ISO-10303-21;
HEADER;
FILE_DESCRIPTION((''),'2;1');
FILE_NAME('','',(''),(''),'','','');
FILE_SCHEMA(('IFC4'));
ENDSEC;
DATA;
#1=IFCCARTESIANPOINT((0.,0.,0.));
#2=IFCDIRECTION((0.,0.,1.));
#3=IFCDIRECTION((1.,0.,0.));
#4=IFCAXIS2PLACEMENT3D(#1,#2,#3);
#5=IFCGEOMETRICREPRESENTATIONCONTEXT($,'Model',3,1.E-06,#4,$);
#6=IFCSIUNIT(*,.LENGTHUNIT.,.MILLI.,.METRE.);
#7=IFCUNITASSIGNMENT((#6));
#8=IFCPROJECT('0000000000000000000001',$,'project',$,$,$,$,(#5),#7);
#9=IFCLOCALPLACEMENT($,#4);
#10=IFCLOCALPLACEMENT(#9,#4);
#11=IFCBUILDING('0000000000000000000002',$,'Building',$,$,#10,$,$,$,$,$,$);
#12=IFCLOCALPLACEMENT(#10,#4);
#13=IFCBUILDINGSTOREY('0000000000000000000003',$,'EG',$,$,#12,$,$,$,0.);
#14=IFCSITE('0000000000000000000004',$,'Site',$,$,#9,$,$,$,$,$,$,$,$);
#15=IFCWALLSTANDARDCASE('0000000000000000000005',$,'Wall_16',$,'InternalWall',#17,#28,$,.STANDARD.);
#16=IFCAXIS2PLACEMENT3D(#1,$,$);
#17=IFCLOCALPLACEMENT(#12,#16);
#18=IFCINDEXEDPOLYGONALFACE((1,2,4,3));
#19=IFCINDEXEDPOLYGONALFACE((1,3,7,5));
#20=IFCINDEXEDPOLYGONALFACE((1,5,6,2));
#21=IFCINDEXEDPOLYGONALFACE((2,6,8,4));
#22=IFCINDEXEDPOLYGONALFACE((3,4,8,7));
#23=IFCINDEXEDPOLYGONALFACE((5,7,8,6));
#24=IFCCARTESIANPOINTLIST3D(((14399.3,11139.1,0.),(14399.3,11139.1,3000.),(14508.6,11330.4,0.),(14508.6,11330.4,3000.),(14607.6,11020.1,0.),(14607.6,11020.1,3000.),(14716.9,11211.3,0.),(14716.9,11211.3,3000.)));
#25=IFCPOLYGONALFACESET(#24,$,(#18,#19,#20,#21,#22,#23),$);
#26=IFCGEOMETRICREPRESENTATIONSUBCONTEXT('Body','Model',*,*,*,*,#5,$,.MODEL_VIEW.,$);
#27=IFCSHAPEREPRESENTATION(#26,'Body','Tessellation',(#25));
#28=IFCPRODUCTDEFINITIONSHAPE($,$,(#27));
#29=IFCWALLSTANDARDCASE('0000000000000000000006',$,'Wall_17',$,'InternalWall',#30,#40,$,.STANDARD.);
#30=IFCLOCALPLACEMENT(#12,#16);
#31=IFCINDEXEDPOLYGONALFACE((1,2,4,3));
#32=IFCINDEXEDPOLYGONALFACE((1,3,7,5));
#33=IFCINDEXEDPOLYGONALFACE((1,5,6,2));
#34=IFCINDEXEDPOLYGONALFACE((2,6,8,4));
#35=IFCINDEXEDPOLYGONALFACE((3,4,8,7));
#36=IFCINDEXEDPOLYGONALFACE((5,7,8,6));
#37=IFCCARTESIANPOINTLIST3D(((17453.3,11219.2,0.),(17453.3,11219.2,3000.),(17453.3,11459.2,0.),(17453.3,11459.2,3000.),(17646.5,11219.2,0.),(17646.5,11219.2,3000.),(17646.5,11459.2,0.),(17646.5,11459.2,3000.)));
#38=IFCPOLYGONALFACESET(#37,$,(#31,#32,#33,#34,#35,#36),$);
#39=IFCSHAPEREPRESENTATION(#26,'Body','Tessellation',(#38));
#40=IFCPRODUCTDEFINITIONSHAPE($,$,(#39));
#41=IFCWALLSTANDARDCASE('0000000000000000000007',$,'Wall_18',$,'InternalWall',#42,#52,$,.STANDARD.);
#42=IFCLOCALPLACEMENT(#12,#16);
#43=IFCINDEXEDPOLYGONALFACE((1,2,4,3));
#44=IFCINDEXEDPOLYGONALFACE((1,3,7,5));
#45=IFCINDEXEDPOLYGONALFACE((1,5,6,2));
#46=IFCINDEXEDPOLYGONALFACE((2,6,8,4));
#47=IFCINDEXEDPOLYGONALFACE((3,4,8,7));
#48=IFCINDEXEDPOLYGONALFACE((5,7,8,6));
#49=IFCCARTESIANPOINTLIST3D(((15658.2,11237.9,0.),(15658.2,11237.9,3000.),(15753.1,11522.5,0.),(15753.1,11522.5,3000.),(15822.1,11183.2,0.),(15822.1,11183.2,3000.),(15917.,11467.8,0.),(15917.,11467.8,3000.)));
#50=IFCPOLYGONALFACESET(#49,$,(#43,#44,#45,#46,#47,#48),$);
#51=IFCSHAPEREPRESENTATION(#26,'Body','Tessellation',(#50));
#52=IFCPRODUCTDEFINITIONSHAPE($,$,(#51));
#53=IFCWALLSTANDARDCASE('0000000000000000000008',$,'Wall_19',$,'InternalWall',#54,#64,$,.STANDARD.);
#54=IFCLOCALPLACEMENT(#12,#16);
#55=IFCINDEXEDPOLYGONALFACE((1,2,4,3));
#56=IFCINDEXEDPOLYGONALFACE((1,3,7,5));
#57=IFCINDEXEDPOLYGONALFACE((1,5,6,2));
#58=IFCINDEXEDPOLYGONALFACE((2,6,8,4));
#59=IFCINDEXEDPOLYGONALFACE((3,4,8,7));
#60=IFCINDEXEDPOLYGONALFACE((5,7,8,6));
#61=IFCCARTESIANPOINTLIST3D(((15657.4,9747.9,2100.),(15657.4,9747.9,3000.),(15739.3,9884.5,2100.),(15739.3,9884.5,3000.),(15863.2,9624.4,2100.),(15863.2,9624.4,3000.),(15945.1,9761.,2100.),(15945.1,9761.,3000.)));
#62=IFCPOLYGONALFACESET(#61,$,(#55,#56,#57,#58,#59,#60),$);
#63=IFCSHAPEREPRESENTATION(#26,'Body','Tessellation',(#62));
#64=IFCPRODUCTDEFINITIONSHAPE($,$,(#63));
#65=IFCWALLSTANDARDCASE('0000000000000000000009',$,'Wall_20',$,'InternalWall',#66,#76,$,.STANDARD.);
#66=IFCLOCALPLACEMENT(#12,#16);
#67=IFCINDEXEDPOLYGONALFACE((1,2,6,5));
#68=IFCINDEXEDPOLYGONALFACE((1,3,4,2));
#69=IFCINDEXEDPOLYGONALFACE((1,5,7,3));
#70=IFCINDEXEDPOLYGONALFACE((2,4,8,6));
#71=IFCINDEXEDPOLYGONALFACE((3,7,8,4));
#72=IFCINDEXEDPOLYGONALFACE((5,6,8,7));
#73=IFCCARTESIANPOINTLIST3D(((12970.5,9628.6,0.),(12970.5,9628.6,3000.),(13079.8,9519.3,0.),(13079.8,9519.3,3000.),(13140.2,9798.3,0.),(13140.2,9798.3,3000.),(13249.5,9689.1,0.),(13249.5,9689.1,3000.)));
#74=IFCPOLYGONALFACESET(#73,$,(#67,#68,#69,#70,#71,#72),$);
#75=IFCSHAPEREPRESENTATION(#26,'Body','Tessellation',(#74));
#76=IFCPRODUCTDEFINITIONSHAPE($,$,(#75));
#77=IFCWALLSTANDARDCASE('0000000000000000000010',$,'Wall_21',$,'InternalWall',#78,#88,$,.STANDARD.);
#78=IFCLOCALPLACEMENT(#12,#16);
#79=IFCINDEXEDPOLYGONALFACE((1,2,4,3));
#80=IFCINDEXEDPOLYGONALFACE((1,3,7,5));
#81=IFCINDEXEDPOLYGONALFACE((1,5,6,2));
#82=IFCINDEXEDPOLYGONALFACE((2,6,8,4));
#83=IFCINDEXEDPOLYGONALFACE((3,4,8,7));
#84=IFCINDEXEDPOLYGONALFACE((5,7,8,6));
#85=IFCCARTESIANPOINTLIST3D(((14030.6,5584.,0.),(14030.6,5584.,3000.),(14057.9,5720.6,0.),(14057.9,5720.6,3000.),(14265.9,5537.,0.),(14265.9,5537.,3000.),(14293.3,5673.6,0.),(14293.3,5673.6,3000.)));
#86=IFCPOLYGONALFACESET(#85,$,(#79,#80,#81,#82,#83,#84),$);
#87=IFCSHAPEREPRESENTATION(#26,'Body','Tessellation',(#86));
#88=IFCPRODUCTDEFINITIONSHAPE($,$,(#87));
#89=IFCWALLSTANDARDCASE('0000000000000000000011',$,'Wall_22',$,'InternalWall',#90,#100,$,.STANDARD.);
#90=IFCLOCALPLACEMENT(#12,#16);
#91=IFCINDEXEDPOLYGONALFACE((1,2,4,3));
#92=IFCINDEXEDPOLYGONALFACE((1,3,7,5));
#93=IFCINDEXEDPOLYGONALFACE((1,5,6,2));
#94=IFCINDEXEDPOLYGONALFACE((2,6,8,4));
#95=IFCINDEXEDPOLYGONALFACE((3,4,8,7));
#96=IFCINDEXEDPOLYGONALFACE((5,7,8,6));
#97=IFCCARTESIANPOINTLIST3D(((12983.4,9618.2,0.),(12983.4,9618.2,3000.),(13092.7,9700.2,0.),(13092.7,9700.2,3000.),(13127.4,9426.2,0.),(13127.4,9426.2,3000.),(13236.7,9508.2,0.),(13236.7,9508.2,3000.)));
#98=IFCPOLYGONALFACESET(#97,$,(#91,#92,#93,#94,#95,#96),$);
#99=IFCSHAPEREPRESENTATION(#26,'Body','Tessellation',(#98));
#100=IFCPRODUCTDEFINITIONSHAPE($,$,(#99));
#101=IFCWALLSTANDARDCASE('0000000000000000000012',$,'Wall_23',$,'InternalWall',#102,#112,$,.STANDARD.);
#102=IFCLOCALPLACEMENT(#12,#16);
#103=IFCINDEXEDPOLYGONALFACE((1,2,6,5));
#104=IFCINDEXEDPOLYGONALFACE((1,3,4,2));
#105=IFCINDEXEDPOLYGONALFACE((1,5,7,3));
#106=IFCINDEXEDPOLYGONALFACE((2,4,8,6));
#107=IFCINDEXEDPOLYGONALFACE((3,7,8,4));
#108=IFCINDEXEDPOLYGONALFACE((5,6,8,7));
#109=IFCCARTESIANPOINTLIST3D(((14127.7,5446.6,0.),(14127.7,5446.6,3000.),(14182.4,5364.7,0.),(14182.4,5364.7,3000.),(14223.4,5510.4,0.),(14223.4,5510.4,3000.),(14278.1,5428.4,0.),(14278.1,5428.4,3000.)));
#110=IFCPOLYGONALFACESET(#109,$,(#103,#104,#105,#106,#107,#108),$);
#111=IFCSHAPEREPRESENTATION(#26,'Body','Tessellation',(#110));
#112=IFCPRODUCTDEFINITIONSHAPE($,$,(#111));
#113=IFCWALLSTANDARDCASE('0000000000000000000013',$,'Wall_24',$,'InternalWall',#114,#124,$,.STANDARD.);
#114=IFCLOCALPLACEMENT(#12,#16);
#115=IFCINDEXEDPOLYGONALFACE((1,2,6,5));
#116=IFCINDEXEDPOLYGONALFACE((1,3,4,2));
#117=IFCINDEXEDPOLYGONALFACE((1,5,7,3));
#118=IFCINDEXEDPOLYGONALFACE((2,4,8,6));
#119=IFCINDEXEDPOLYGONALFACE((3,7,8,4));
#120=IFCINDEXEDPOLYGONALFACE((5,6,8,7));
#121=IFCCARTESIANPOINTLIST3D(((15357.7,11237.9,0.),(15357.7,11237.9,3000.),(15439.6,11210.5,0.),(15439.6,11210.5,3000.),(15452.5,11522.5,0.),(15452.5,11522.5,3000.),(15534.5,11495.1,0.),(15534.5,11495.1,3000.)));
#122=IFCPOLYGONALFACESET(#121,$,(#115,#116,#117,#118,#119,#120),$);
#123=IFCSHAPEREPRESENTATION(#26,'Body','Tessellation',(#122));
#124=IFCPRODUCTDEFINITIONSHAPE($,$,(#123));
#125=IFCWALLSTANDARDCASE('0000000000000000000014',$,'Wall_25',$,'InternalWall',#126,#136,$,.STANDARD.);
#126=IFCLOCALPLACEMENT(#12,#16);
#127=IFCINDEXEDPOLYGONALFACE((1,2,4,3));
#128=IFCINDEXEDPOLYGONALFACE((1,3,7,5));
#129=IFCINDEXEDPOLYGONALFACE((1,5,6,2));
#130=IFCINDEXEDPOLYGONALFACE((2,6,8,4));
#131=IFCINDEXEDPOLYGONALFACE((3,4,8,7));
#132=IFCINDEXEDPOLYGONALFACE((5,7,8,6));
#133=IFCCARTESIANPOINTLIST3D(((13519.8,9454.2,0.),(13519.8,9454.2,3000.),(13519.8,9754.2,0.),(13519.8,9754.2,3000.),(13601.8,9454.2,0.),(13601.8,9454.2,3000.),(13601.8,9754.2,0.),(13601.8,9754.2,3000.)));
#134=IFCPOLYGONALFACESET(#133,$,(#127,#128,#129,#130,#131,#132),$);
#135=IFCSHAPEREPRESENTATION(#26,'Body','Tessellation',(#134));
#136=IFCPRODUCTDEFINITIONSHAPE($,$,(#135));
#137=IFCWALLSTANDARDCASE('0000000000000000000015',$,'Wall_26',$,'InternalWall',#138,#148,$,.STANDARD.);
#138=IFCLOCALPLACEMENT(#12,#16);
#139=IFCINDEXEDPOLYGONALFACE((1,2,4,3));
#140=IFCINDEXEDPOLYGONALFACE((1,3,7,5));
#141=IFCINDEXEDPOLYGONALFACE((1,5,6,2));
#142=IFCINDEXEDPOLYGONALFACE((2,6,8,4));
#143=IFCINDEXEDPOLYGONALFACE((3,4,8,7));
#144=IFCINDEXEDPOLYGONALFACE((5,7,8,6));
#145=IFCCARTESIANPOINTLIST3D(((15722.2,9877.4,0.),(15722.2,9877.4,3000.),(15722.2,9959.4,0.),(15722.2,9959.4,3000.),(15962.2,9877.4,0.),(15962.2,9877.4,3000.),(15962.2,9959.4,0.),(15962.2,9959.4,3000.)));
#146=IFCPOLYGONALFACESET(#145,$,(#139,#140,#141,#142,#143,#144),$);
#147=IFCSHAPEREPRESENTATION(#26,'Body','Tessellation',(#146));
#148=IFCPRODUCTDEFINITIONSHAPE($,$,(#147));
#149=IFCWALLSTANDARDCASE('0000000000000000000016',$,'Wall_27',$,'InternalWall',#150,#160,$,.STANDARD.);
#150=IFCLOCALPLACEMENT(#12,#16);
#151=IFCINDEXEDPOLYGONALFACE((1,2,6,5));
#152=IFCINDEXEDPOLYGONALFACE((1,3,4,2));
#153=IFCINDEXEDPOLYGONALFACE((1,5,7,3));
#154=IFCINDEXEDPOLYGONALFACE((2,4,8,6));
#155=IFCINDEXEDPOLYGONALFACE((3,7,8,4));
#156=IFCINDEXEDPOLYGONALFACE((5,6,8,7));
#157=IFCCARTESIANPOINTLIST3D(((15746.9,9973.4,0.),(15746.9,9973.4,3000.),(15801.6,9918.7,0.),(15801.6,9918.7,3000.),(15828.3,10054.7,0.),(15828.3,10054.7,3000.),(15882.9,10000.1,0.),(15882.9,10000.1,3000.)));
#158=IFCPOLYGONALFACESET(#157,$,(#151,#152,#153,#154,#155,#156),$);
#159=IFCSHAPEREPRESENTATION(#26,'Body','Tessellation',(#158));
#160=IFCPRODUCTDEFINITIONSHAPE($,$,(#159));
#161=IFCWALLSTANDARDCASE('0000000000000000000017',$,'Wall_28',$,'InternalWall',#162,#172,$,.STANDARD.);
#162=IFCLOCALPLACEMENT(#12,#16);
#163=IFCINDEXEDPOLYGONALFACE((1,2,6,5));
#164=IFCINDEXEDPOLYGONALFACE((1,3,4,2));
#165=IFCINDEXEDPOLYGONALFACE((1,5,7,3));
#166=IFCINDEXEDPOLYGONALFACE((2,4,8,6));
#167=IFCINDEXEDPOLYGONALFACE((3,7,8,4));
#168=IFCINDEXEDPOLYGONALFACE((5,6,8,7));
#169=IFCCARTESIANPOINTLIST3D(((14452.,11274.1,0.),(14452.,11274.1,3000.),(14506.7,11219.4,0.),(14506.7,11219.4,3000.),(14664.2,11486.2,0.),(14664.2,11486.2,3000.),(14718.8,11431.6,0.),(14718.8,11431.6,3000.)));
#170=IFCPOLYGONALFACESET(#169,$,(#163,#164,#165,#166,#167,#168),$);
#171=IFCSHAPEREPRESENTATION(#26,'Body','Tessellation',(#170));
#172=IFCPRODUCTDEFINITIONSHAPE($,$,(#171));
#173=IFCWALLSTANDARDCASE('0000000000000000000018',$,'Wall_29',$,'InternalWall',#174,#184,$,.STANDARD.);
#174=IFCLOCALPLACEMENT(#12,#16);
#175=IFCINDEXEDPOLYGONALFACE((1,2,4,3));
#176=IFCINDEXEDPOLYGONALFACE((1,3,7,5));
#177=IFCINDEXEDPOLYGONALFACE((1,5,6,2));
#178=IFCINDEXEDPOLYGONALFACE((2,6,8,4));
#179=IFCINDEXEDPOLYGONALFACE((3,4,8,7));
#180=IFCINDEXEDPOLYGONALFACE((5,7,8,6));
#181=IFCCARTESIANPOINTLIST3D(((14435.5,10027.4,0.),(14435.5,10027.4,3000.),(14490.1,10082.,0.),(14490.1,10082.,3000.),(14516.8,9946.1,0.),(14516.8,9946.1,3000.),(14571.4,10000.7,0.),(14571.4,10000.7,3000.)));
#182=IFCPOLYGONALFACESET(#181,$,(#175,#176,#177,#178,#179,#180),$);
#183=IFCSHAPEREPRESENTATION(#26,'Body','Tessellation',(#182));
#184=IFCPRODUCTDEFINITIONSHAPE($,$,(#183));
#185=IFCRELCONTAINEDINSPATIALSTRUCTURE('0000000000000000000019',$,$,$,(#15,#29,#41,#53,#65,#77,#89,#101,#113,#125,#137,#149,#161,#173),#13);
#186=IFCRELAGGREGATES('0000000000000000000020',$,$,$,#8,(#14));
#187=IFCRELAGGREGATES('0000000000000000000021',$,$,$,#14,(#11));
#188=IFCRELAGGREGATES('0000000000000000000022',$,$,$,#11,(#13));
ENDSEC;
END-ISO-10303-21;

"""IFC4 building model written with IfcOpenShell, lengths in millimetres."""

from ifc_helpers import new_model, si_unit, frame, origin_with_axes, place, context, subcontext, project, spatial, rectangle, extrude, element, save


model = new_model("IFC4")

# Units and contexts
model_context = context("Model", 3, precision=1e-06, world=origin_with_axes())
body_context = subcontext(model_context, "Body", "Model", "MODEL_VIEW")
ifc_project = project(units=[si_unit("LENGTHUNIT", "METRE", prefix="MILLI")], contexts=[model_context])

# Site, building, storey
site_placement = place(None, origin_with_axes())
site = spatial("IfcSite", under=ifc_project, at=site_placement, Name="Site")
building_placement = place(site_placement, origin_with_axes())
building = spatial("IfcBuilding", under=site, at=building_placement, Name="Building")
storey_placement = place(building_placement, origin_with_axes())
storey = spatial("IfcBuildingStorey", under=building, at=storey_placement, Name="EG", Elevation=0.0)

# Walls
wall_1_placement = place(storey_placement, origin_with_axes())
element("IfcWallStandardCase", 1, at=wall_1_placement, inside=storey, Name="Wall_16", ObjectType="InternalWall", PredefinedType="STANDARD", context=body_context, shape_type="SweptSolid", body=[
    extrude(rectangle(XDim=220.3, YDim=240.0), frame((14558.1, 11175.2, 0.0), z_axis=(0.0, 0.0, 1.0), x_axis=(-0.496139, -0.868243, 0.0)), (0.0, 0.0, 1.0), 3000.0),
])
wall_2_placement = place(storey_placement, origin_with_axes())
element("IfcWallStandardCase", 2, at=wall_2_placement, inside=storey, Name="Wall_17", ObjectType="InternalWall", PredefinedType="STANDARD", context=body_context, shape_type="SweptSolid", body=[
    extrude(rectangle(XDim=193.2, YDim=240.0), frame((17549.9, 11339.2, 0.0), z_axis=(0.0, 0.0, 1.0), x_axis=(1.0, 0.0, 0.0)), (0.0, 0.0, 1.0), 3000.0),
])
wall_3_placement = place(storey_placement, origin_with_axes())
element("IfcWallStandardCase", 3, at=wall_3_placement, inside=storey, Name="Wall_18", ObjectType="InternalWall", PredefinedType="STANDARD", context=body_context, shape_type="SweptSolid", body=[
    extrude(rectangle(XDim=172.8, YDim=300.0), frame((15787.6, 11352.8, 0.0), z_axis=(0.0, 0.0, 1.0), x_axis=(0.948683, -0.316228, 0.0)), (0.0, 0.0, 1.0), 3000.0),
])

# Wall, opening
wall_4_placement = place(storey_placement, origin_with_axes())
wall_4 = element("IfcWallStandardCase", 4, at=wall_4_placement, inside=storey, Name="Wall_19", ObjectType="InternalWall", PredefinedType="STANDARD", context=body_context, shape_type="SweptSolid", body=[
    extrude(rectangle(XDim=159.3, YDim=240.0), frame((15801.3, 9754.5, 0.0), z_axis=(0.0, 0.0, 1.0), x_axis=(0.514496, 0.857493, 0.0)), (0.0, 0.0, 1.0), 3000.0),
])
opening_1_placement = place(wall_4_placement, origin_with_axes())
element("IfcOpeningElement", 5, at=opening_1_placement, inside=storey, cuts=wall_4, context=body_context, shape_type="SweptSolid", body=[
    extrude(rectangle(XDim=1701.6, YDim=240.0), frame((15641.2, 9487.7, 0.0), z_axis=(0.0, 0.0, 1.0), x_axis=(0.514496, 0.857493, 0.0)), (0.0, 0.0, 1.0), 2100.0),
])

# Walls
wall_5_placement = place(storey_placement, origin_with_axes())
element("IfcWallStandardCase", 6, at=wall_5_placement, inside=storey, Name="Wall_20", ObjectType="InternalWall", PredefinedType="STANDARD", context=body_context, shape_type="SweptSolid", body=[
    extrude(rectangle(XDim=154.6, YDim=240.0), frame((13110.0, 9658.8, 0.0), z_axis=(0.0, 0.0, 1.0), x_axis=(-0.707107, 0.707107, 0.0)), (0.0, 0.0, 1.0), 3000.0),
])
wall_6_placement = place(storey_placement, origin_with_axes())
element("IfcWallStandardCase", 7, at=wall_6_placement, inside=storey, Name="Wall_21", ObjectType="InternalWall", PredefinedType="STANDARD", context=body_context, shape_type="SweptSolid", body=[
    extrude(rectangle(XDim=139.3, YDim=240.0), frame((14161.9, 5628.8, 0.0), z_axis=(0.0, 0.0, 1.0), x_axis=(-0.196116, -0.980581, 0.0)), (0.0, 0.0, 1.0), 3000.0),
])
wall_7_placement = place(storey_placement, origin_with_axes())
element("IfcWallStandardCase", 8, at=wall_7_placement, inside=storey, Name="Wall_22", ObjectType="InternalWall", PredefinedType="STANDARD", context=body_context, shape_type="SweptSolid", body=[
    extrude(rectangle(XDim=136.6, YDim=240.0), frame((13110.0, 9563.2, 0.0), z_axis=(0.0, 0.0, 1.0), x_axis=(-0.8, -0.6, 0.0)), (0.0, 0.0, 1.0), 3000.0),
])
wall_8_placement = place(storey_placement, origin_with_axes())
element("IfcWallStandardCase", 9, at=wall_8_placement, inside=storey, Name="Wall_23", ObjectType="InternalWall", PredefinedType="STANDARD", context=body_context, shape_type="SweptSolid", body=[
    extrude(rectangle(XDim=98.5, YDim=115.0), frame((14202.9, 5437.5, 0.0), z_axis=(0.0, 0.0, 1.0), x_axis=(0.5547, -0.83205, 0.0)), (0.0, 0.0, 1.0), 3000.0),
])
wall_9_placement = place(storey_placement, origin_with_axes())
element("IfcWallStandardCase", 10, at=wall_9_placement, inside=storey, Name="Wall_24", ObjectType="InternalWall", PredefinedType="STANDARD", context=body_context, shape_type="SweptSolid", body=[
    extrude(rectangle(XDim=86.4, YDim=300.0), frame((15446.1, 11366.5, 0.0), z_axis=(0.0, 0.0, 1.0), x_axis=(0.948683, -0.316228, 0.0)), (0.0, 0.0, 1.0), 3000.0),
])
wall_10_placement = place(storey_placement, origin_with_axes())
element("IfcWallStandardCase", 11, at=wall_10_placement, inside=storey, Name="Wall_25", ObjectType="InternalWall", PredefinedType="STANDARD", context=body_context, shape_type="SweptSolid", body=[
    extrude(rectangle(XDim=82.0, YDim=300.0), frame((13560.8, 9604.2, 0.0), z_axis=(0.0, 0.0, 1.0), x_axis=(-1.0, 0.0, 0.0)), (0.0, 0.0, 1.0), 3000.0),
])
wall_11_placement = place(storey_placement, origin_with_axes())
element("IfcWallStandardCase", 12, at=wall_11_placement, inside=storey, Name="Wall_26", ObjectType="InternalWall", PredefinedType="STANDARD", context=body_context, shape_type="SweptSolid", body=[
    extrude(rectangle(XDim=82.0, YDim=240.0), frame((15842.2, 9918.4, 0.0), z_axis=(0.0, 0.0, 1.0), x_axis=(0.0, 1.0, 0.0)), (0.0, 0.0, 1.0), 3000.0),
])
wall_12_placement = place(storey_placement, origin_with_axes())
element("IfcWallStandardCase", 13, at=wall_12_placement, inside=storey, Name="Wall_27", ObjectType="InternalWall", PredefinedType="STANDARD", context=body_context, shape_type="SweptSolid", body=[
    extrude(rectangle(XDim=77.3, YDim=115.0), frame((15814.9, 9986.7, 0.0), z_axis=(0.0, 0.0, 1.0), x_axis=(-0.707107, 0.707107, 0.0)), (0.0, 0.0, 1.0), 3000.0),
])
wall_13_placement = place(storey_placement, origin_with_axes())
element("IfcWallStandardCase", 14, at=wall_13_placement, inside=storey, Name="Wall_28", ObjectType="InternalWall", PredefinedType="STANDARD", context=body_context, shape_type="SweptSolid", body=[
    extrude(rectangle(XDim=77.3, YDim=300.0), frame((14585.4, 11352.8, 0.0), z_axis=(0.0, 0.0, 1.0), x_axis=(-0.707107, 0.707107, 0.0)), (0.0, 0.0, 1.0), 3000.0),
])
wall_14_placement = place(storey_placement, origin_with_axes())
element("IfcWallStandardCase", 15, at=wall_14_placement, inside=storey, Name="Wall_29", ObjectType="InternalWall", PredefinedType="STANDARD", context=body_context, shape_type="SweptSolid", body=[
    extrude(rectangle(XDim=77.3, YDim=115.0), frame((14503.5, 10014.0, 0.0), z_axis=(0.0, 0.0, 1.0), x_axis=(0.707107, 0.707107, 0.0)), (0.0, 0.0, 1.0), 3000.0),
])

save(model, "model.ifc")
